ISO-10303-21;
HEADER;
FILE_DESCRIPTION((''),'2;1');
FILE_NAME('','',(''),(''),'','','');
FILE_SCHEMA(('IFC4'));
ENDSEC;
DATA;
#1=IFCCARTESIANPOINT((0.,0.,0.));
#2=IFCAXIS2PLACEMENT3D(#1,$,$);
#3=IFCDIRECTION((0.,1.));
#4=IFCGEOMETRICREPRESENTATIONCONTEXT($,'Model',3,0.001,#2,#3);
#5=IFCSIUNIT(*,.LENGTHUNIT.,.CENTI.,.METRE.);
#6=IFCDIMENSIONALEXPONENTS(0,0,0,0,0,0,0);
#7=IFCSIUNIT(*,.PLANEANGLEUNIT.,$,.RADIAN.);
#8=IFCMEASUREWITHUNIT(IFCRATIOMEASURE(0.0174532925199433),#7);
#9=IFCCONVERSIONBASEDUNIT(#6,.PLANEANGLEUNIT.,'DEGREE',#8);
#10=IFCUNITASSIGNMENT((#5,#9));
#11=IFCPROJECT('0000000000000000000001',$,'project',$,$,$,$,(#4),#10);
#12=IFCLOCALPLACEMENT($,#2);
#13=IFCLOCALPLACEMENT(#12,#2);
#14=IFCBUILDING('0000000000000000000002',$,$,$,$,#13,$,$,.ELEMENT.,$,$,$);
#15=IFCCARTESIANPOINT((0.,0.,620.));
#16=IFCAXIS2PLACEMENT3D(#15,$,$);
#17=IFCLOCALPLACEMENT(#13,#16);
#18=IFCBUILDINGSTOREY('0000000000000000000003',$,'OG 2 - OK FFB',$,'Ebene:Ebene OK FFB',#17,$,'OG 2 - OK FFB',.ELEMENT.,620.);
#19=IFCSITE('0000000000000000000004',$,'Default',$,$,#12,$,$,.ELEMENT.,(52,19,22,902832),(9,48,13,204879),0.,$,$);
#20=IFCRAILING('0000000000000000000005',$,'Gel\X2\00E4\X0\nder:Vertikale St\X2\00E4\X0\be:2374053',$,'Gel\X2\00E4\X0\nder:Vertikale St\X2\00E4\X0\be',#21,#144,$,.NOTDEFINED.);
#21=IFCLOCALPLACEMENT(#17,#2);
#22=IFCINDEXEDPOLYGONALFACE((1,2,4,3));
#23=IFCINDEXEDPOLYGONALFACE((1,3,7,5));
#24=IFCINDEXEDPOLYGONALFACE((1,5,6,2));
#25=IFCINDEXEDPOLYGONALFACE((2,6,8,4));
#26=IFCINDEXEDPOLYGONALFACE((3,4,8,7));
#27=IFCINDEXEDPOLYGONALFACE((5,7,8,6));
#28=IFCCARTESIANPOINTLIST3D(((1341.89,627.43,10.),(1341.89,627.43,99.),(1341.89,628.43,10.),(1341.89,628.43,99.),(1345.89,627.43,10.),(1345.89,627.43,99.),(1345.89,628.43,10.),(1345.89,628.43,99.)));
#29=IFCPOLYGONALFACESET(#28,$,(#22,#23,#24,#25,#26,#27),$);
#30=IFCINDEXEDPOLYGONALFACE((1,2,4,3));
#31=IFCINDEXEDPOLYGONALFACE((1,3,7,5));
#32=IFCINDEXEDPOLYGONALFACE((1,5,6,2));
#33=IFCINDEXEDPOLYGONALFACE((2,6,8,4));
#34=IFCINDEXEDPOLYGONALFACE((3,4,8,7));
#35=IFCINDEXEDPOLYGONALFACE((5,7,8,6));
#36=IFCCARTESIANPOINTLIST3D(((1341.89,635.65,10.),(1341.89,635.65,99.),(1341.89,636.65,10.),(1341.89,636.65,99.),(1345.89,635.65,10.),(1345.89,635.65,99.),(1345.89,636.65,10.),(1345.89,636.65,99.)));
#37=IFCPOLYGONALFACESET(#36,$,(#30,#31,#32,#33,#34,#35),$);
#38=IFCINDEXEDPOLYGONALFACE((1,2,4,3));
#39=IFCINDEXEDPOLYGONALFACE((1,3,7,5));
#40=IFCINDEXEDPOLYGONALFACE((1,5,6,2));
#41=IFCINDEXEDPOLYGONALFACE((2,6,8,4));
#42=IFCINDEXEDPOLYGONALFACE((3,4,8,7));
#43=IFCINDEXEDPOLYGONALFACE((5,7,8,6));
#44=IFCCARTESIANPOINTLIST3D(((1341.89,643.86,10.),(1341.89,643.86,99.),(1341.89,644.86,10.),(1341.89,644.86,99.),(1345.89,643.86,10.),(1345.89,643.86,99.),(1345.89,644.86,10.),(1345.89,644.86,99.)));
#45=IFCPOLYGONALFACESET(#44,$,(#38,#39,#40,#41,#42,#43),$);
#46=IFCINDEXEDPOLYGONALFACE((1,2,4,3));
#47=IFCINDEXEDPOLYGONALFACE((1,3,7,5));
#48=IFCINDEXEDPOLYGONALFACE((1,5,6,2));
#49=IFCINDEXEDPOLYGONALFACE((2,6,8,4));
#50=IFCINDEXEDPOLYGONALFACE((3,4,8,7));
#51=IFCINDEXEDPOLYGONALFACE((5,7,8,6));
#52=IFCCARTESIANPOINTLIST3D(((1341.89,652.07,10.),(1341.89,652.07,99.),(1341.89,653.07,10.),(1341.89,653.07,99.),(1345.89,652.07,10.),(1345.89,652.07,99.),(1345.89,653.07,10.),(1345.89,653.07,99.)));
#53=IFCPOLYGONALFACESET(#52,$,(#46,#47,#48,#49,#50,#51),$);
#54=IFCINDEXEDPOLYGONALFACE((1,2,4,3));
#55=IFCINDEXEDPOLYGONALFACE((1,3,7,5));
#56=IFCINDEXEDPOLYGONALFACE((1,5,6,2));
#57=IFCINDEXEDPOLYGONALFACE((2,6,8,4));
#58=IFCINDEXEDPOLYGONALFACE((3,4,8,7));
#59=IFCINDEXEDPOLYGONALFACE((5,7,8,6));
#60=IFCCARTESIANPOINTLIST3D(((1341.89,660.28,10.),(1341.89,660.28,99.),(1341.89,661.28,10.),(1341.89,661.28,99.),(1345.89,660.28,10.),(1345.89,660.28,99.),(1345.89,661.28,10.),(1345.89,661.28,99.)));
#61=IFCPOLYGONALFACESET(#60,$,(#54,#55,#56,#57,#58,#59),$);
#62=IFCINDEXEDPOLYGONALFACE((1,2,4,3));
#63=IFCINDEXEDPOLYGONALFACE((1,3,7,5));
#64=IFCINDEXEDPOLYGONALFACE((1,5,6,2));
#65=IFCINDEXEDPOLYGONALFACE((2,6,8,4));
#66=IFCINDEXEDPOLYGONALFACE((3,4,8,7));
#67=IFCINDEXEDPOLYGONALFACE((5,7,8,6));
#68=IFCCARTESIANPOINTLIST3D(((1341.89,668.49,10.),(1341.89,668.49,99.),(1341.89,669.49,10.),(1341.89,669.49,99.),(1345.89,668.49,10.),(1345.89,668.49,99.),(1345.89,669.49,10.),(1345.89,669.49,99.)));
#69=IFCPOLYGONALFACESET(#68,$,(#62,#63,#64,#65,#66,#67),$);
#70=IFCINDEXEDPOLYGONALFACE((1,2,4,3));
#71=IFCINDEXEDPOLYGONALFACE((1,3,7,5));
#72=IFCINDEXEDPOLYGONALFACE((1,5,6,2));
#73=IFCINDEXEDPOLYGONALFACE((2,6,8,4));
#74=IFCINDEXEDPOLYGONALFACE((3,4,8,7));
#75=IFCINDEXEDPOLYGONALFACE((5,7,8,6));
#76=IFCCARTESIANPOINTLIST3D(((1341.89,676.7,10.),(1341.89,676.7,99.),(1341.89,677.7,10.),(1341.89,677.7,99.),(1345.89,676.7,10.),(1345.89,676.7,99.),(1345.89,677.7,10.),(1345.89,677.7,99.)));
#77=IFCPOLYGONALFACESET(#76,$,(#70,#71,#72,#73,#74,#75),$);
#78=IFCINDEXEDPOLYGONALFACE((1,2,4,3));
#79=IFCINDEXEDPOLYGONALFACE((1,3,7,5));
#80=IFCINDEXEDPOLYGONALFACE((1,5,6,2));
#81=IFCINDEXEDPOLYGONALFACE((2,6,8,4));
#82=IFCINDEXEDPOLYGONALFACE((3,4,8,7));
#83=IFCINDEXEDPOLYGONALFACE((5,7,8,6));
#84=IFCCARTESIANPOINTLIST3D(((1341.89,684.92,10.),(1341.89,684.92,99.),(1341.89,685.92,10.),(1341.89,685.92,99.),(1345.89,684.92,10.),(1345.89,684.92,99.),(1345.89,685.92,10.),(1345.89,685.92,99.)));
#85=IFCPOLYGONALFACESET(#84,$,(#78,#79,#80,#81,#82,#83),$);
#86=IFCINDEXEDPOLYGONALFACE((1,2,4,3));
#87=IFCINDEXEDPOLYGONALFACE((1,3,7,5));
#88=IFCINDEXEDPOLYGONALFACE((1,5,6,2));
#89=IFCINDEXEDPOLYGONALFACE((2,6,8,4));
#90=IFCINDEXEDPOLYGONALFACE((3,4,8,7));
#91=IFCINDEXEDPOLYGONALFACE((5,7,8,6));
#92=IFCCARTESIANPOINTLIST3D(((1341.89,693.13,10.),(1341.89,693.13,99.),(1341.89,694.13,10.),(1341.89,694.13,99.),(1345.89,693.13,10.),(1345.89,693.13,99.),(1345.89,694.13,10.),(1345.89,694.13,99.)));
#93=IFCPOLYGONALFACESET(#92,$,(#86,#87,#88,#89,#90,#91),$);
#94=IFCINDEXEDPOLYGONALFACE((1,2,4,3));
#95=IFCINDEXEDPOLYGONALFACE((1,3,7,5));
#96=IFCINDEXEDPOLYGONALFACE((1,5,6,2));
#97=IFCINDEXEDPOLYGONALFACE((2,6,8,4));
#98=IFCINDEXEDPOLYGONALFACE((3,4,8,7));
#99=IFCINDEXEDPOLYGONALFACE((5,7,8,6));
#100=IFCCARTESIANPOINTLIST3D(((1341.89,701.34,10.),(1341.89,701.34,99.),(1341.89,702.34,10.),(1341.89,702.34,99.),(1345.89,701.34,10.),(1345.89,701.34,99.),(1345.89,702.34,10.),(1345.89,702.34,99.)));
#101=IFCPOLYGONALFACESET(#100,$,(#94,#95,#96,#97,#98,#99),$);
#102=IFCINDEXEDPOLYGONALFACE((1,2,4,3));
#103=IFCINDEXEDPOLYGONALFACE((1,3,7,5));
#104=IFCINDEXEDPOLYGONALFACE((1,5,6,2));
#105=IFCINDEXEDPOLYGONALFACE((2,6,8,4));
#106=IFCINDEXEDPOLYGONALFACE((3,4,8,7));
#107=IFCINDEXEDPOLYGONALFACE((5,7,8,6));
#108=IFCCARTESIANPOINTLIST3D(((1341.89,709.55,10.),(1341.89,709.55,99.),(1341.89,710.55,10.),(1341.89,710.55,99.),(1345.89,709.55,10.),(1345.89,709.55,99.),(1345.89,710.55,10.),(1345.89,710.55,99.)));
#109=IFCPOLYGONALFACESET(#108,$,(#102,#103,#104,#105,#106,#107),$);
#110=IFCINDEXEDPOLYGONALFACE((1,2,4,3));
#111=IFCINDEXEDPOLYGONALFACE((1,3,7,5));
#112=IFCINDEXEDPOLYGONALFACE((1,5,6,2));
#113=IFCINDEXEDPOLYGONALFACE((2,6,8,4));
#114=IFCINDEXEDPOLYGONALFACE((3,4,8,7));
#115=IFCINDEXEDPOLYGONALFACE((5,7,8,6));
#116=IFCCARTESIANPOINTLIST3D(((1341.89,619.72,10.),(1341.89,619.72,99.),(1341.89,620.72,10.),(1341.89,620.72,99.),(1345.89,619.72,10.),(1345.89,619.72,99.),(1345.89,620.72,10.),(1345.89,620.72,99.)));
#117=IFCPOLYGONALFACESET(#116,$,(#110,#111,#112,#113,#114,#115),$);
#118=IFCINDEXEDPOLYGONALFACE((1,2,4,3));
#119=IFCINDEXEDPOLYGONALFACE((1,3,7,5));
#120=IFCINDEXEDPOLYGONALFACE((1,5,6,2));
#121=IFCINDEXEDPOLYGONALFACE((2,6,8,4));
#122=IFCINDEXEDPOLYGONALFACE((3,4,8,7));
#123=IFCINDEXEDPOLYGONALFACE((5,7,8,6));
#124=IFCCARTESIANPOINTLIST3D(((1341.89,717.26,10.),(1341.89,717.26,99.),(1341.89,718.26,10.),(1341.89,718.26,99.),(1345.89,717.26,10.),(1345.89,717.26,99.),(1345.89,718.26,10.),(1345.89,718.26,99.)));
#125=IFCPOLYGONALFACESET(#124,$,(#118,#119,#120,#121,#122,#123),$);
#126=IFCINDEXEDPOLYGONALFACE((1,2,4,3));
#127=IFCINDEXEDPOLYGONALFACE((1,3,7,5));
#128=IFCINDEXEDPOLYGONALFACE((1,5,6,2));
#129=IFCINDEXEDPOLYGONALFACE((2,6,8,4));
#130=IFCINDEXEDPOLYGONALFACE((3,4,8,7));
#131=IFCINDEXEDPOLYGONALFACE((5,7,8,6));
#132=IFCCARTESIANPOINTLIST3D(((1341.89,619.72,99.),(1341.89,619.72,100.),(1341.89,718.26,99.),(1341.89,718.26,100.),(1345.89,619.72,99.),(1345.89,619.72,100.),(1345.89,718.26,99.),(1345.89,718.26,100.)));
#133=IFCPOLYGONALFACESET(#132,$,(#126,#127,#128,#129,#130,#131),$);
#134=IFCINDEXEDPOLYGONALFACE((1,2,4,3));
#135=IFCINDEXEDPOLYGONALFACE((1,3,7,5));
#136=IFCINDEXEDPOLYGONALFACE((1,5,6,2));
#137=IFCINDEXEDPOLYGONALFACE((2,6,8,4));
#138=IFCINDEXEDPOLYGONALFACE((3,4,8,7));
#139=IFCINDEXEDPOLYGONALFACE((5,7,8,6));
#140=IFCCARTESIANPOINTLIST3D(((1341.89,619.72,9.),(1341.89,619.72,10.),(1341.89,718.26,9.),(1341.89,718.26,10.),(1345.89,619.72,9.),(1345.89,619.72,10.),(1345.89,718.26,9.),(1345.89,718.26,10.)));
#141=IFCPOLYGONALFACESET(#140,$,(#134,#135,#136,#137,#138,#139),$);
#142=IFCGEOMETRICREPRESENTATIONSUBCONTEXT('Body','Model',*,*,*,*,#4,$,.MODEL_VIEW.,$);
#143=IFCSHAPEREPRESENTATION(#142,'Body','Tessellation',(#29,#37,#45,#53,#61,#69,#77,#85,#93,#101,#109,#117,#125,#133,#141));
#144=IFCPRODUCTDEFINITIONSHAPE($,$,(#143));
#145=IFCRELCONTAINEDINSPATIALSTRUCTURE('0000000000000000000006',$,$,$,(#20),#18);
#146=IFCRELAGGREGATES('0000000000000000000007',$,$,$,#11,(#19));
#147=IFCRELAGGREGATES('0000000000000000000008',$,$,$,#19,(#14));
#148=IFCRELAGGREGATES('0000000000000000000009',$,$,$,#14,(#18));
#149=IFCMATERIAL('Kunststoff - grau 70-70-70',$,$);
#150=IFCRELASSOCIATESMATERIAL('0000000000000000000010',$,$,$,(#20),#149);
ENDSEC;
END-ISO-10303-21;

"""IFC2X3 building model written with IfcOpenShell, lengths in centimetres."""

from ifc_helpers import new_model, entity, si_unit, converted_unit, direction, frame, frame_2d, origin, origin_2d_with_axis, place, context, subcontext, project, spatial, rectangle, extrude, material, element, save


model = new_model("IFC2X3")

# Units and contexts
model_context = context("Model", 3, precision=0.001, world=origin(), true_north=direction((0.0, 1.0)))
body_context = subcontext(model_context, "Body", "Model", "MODEL_VIEW")
ifc_project = project(units=[si_unit("LENGTHUNIT", "METRE", prefix="CENTI"), converted_unit("PLANEANGLEUNIT", "DEGREE", entity("IfcRatioMeasure", 0.0174532925199433), si_unit("PLANEANGLEUNIT", "RADIAN"), dimensions=[0, 0, 0, 0, 0, 0, 0])], contexts=[model_context])

# Site, building, storey
site_placement = place(None, frame((0.0, 0.0, 0.0)))
site = spatial("IfcSite", under=ifc_project, at=site_placement, Name="Default", CompositionType="ELEMENT", RefLatitude=(52, 19, 22, 902832), RefLongitude=(9, 48, 13, 204879), RefElevation=0.0)
building_placement = place(site_placement, origin())
building = spatial("IfcBuilding", under=site, at=building_placement, CompositionType="ELEMENT")
storey_placement = place(building_placement, frame((0.0, 0.0, 620.0)))
storey = spatial("IfcBuildingStorey", under=building, at=storey_placement, Name="OG 2 - OK FFB", ObjectType="Ebene:Ebene OK FFB", LongName="OG 2 - OK FFB", CompositionType="ELEMENT", Elevation=620.0)

# Railing
ifc_material = material(Name="Kunststoff - grau 70-70-70")
railing_placement = place(storey_placement, origin())
element("IfcRailing", 1, at=railing_placement, inside=storey, material=ifc_material, Name="Geländer:Vertikale Stäbe:2374053", ObjectType="Geländer:Vertikale Stäbe", PredefinedType="NOTDEFINED", context=body_context, shape_type="SweptSolid", body=[
    extrude(rectangle(XDim=1.0, YDim=4.0, at=origin_2d_with_axis()), frame((1343.89, 627.93, 10.0), z_axis=(0.0, 0.0, 1.0), x_axis=(0.0, -1.0, 0.0)), (0.0, 0.0, 1.0), 89.0),
    extrude(rectangle(XDim=1.0, YDim=4.0, at=origin_2d_with_axis()), frame((1343.89, 636.15, 10.0), z_axis=(0.0, 0.0, 1.0), x_axis=(0.0, -1.0, 0.0)), (0.0, 0.0, 1.0), 89.0),
    extrude(rectangle(XDim=1.0, YDim=4.0, at=origin_2d_with_axis()), frame((1343.89, 644.36, 10.0), z_axis=(0.0, 0.0, 1.0), x_axis=(0.0, -1.0, 0.0)), (0.0, 0.0, 1.0), 89.0),
    extrude(rectangle(XDim=1.0, YDim=4.0, at=origin_2d_with_axis()), frame((1343.89, 652.57, 10.0), z_axis=(0.0, 0.0, 1.0), x_axis=(0.0, -1.0, 0.0)), (0.0, 0.0, 1.0), 89.0),
    extrude(rectangle(XDim=1.0, YDim=4.0, at=frame_2d((0.0, 0.0), x_axis=(1.0, 0.0))), frame((1343.89, 660.78, 10.0), z_axis=(0.0, 0.0, 1.0), x_axis=(0.0, -1.0, 0.0)), (0.0, 0.0, 1.0), 89.0),
    extrude(rectangle(XDim=1.0, YDim=4.0, at=origin_2d_with_axis()), frame((1343.89, 668.99, 10.0), z_axis=(0.0, 0.0, 1.0), x_axis=(0.0, -1.0, 0.0)), (0.0, 0.0, 1.0), 89.0),
    extrude(rectangle(XDim=1.0, YDim=4.0, at=origin_2d_with_axis()), frame((1343.89, 677.2, 10.0), z_axis=(0.0, 0.0, 1.0), x_axis=(0.0, -1.0, 0.0)), (0.0, 0.0, 1.0), 89.0),
    extrude(rectangle(XDim=1.0, YDim=4.0, at=origin_2d_with_axis()), frame((1343.89, 685.42, 10.0), z_axis=(0.0, 0.0, 1.0), x_axis=(0.0, -1.0, 0.0)), (0.0, 0.0, 1.0), 89.0),
    extrude(rectangle(XDim=1.0, YDim=4.0, at=origin_2d_with_axis()), frame((1343.89, 693.63, 10.0), z_axis=(0.0, 0.0, 1.0), x_axis=(0.0, -1.0, 0.0)), (0.0, 0.0, 1.0), 89.0),
    extrude(rectangle(XDim=1.0, YDim=4.0, at=origin_2d_with_axis()), frame((1343.89, 701.84, 10.0), z_axis=(0.0, 0.0, 1.0), x_axis=(0.0, -1.0, 0.0)), (0.0, 0.0, 1.0), 89.0),
    extrude(rectangle(XDim=1.0, YDim=4.0, at=origin_2d_with_axis()), frame((1343.89, 710.05, 10.0), z_axis=(0.0, 0.0, 1.0), x_axis=(0.0, -1.0, 0.0)), (0.0, 0.0, 1.0), 89.0),
    extrude(rectangle(XDim=1.0, YDim=4.0, at=origin_2d_with_axis()), frame((1343.89, 620.22, 10.0), z_axis=(0.0, 0.0, 1.0), x_axis=(0.0, -1.0, 0.0)), (0.0, 0.0, 1.0), 89.0),
    extrude(rectangle(XDim=1.0, YDim=4.0, at=frame_2d((0.0, 0.0), x_axis=(1.0, 0.0))), frame((1343.89, 717.76, 10.0), z_axis=(0.0, 0.0, 1.0), x_axis=(0.0, -1.0, 0.0)), (0.0, 0.0, 1.0), 89.0),
    extrude(rectangle(XDim=98.54, YDim=4.0, at=frame_2d((0.0, 0.0), x_axis=(1.0, 0.0))), frame((1343.89, 668.99, 99.0), z_axis=(0.0, 0.0, 1.0), x_axis=(0.0, -1.0, 0.0)), (0.0, 0.0, 1.0), 1.0),
    extrude(rectangle(XDim=98.54, YDim=4.0, at=frame_2d((0.0, 0.0), x_axis=(1.0, 0.0))), frame((1343.89, 668.99, 9.0), z_axis=(0.0, 0.0, 1.0), x_axis=(0.0, -1.0, 0.0)), (0.0, 0.0, 1.0), 1.0),
])

save(model, "model.ifc")
